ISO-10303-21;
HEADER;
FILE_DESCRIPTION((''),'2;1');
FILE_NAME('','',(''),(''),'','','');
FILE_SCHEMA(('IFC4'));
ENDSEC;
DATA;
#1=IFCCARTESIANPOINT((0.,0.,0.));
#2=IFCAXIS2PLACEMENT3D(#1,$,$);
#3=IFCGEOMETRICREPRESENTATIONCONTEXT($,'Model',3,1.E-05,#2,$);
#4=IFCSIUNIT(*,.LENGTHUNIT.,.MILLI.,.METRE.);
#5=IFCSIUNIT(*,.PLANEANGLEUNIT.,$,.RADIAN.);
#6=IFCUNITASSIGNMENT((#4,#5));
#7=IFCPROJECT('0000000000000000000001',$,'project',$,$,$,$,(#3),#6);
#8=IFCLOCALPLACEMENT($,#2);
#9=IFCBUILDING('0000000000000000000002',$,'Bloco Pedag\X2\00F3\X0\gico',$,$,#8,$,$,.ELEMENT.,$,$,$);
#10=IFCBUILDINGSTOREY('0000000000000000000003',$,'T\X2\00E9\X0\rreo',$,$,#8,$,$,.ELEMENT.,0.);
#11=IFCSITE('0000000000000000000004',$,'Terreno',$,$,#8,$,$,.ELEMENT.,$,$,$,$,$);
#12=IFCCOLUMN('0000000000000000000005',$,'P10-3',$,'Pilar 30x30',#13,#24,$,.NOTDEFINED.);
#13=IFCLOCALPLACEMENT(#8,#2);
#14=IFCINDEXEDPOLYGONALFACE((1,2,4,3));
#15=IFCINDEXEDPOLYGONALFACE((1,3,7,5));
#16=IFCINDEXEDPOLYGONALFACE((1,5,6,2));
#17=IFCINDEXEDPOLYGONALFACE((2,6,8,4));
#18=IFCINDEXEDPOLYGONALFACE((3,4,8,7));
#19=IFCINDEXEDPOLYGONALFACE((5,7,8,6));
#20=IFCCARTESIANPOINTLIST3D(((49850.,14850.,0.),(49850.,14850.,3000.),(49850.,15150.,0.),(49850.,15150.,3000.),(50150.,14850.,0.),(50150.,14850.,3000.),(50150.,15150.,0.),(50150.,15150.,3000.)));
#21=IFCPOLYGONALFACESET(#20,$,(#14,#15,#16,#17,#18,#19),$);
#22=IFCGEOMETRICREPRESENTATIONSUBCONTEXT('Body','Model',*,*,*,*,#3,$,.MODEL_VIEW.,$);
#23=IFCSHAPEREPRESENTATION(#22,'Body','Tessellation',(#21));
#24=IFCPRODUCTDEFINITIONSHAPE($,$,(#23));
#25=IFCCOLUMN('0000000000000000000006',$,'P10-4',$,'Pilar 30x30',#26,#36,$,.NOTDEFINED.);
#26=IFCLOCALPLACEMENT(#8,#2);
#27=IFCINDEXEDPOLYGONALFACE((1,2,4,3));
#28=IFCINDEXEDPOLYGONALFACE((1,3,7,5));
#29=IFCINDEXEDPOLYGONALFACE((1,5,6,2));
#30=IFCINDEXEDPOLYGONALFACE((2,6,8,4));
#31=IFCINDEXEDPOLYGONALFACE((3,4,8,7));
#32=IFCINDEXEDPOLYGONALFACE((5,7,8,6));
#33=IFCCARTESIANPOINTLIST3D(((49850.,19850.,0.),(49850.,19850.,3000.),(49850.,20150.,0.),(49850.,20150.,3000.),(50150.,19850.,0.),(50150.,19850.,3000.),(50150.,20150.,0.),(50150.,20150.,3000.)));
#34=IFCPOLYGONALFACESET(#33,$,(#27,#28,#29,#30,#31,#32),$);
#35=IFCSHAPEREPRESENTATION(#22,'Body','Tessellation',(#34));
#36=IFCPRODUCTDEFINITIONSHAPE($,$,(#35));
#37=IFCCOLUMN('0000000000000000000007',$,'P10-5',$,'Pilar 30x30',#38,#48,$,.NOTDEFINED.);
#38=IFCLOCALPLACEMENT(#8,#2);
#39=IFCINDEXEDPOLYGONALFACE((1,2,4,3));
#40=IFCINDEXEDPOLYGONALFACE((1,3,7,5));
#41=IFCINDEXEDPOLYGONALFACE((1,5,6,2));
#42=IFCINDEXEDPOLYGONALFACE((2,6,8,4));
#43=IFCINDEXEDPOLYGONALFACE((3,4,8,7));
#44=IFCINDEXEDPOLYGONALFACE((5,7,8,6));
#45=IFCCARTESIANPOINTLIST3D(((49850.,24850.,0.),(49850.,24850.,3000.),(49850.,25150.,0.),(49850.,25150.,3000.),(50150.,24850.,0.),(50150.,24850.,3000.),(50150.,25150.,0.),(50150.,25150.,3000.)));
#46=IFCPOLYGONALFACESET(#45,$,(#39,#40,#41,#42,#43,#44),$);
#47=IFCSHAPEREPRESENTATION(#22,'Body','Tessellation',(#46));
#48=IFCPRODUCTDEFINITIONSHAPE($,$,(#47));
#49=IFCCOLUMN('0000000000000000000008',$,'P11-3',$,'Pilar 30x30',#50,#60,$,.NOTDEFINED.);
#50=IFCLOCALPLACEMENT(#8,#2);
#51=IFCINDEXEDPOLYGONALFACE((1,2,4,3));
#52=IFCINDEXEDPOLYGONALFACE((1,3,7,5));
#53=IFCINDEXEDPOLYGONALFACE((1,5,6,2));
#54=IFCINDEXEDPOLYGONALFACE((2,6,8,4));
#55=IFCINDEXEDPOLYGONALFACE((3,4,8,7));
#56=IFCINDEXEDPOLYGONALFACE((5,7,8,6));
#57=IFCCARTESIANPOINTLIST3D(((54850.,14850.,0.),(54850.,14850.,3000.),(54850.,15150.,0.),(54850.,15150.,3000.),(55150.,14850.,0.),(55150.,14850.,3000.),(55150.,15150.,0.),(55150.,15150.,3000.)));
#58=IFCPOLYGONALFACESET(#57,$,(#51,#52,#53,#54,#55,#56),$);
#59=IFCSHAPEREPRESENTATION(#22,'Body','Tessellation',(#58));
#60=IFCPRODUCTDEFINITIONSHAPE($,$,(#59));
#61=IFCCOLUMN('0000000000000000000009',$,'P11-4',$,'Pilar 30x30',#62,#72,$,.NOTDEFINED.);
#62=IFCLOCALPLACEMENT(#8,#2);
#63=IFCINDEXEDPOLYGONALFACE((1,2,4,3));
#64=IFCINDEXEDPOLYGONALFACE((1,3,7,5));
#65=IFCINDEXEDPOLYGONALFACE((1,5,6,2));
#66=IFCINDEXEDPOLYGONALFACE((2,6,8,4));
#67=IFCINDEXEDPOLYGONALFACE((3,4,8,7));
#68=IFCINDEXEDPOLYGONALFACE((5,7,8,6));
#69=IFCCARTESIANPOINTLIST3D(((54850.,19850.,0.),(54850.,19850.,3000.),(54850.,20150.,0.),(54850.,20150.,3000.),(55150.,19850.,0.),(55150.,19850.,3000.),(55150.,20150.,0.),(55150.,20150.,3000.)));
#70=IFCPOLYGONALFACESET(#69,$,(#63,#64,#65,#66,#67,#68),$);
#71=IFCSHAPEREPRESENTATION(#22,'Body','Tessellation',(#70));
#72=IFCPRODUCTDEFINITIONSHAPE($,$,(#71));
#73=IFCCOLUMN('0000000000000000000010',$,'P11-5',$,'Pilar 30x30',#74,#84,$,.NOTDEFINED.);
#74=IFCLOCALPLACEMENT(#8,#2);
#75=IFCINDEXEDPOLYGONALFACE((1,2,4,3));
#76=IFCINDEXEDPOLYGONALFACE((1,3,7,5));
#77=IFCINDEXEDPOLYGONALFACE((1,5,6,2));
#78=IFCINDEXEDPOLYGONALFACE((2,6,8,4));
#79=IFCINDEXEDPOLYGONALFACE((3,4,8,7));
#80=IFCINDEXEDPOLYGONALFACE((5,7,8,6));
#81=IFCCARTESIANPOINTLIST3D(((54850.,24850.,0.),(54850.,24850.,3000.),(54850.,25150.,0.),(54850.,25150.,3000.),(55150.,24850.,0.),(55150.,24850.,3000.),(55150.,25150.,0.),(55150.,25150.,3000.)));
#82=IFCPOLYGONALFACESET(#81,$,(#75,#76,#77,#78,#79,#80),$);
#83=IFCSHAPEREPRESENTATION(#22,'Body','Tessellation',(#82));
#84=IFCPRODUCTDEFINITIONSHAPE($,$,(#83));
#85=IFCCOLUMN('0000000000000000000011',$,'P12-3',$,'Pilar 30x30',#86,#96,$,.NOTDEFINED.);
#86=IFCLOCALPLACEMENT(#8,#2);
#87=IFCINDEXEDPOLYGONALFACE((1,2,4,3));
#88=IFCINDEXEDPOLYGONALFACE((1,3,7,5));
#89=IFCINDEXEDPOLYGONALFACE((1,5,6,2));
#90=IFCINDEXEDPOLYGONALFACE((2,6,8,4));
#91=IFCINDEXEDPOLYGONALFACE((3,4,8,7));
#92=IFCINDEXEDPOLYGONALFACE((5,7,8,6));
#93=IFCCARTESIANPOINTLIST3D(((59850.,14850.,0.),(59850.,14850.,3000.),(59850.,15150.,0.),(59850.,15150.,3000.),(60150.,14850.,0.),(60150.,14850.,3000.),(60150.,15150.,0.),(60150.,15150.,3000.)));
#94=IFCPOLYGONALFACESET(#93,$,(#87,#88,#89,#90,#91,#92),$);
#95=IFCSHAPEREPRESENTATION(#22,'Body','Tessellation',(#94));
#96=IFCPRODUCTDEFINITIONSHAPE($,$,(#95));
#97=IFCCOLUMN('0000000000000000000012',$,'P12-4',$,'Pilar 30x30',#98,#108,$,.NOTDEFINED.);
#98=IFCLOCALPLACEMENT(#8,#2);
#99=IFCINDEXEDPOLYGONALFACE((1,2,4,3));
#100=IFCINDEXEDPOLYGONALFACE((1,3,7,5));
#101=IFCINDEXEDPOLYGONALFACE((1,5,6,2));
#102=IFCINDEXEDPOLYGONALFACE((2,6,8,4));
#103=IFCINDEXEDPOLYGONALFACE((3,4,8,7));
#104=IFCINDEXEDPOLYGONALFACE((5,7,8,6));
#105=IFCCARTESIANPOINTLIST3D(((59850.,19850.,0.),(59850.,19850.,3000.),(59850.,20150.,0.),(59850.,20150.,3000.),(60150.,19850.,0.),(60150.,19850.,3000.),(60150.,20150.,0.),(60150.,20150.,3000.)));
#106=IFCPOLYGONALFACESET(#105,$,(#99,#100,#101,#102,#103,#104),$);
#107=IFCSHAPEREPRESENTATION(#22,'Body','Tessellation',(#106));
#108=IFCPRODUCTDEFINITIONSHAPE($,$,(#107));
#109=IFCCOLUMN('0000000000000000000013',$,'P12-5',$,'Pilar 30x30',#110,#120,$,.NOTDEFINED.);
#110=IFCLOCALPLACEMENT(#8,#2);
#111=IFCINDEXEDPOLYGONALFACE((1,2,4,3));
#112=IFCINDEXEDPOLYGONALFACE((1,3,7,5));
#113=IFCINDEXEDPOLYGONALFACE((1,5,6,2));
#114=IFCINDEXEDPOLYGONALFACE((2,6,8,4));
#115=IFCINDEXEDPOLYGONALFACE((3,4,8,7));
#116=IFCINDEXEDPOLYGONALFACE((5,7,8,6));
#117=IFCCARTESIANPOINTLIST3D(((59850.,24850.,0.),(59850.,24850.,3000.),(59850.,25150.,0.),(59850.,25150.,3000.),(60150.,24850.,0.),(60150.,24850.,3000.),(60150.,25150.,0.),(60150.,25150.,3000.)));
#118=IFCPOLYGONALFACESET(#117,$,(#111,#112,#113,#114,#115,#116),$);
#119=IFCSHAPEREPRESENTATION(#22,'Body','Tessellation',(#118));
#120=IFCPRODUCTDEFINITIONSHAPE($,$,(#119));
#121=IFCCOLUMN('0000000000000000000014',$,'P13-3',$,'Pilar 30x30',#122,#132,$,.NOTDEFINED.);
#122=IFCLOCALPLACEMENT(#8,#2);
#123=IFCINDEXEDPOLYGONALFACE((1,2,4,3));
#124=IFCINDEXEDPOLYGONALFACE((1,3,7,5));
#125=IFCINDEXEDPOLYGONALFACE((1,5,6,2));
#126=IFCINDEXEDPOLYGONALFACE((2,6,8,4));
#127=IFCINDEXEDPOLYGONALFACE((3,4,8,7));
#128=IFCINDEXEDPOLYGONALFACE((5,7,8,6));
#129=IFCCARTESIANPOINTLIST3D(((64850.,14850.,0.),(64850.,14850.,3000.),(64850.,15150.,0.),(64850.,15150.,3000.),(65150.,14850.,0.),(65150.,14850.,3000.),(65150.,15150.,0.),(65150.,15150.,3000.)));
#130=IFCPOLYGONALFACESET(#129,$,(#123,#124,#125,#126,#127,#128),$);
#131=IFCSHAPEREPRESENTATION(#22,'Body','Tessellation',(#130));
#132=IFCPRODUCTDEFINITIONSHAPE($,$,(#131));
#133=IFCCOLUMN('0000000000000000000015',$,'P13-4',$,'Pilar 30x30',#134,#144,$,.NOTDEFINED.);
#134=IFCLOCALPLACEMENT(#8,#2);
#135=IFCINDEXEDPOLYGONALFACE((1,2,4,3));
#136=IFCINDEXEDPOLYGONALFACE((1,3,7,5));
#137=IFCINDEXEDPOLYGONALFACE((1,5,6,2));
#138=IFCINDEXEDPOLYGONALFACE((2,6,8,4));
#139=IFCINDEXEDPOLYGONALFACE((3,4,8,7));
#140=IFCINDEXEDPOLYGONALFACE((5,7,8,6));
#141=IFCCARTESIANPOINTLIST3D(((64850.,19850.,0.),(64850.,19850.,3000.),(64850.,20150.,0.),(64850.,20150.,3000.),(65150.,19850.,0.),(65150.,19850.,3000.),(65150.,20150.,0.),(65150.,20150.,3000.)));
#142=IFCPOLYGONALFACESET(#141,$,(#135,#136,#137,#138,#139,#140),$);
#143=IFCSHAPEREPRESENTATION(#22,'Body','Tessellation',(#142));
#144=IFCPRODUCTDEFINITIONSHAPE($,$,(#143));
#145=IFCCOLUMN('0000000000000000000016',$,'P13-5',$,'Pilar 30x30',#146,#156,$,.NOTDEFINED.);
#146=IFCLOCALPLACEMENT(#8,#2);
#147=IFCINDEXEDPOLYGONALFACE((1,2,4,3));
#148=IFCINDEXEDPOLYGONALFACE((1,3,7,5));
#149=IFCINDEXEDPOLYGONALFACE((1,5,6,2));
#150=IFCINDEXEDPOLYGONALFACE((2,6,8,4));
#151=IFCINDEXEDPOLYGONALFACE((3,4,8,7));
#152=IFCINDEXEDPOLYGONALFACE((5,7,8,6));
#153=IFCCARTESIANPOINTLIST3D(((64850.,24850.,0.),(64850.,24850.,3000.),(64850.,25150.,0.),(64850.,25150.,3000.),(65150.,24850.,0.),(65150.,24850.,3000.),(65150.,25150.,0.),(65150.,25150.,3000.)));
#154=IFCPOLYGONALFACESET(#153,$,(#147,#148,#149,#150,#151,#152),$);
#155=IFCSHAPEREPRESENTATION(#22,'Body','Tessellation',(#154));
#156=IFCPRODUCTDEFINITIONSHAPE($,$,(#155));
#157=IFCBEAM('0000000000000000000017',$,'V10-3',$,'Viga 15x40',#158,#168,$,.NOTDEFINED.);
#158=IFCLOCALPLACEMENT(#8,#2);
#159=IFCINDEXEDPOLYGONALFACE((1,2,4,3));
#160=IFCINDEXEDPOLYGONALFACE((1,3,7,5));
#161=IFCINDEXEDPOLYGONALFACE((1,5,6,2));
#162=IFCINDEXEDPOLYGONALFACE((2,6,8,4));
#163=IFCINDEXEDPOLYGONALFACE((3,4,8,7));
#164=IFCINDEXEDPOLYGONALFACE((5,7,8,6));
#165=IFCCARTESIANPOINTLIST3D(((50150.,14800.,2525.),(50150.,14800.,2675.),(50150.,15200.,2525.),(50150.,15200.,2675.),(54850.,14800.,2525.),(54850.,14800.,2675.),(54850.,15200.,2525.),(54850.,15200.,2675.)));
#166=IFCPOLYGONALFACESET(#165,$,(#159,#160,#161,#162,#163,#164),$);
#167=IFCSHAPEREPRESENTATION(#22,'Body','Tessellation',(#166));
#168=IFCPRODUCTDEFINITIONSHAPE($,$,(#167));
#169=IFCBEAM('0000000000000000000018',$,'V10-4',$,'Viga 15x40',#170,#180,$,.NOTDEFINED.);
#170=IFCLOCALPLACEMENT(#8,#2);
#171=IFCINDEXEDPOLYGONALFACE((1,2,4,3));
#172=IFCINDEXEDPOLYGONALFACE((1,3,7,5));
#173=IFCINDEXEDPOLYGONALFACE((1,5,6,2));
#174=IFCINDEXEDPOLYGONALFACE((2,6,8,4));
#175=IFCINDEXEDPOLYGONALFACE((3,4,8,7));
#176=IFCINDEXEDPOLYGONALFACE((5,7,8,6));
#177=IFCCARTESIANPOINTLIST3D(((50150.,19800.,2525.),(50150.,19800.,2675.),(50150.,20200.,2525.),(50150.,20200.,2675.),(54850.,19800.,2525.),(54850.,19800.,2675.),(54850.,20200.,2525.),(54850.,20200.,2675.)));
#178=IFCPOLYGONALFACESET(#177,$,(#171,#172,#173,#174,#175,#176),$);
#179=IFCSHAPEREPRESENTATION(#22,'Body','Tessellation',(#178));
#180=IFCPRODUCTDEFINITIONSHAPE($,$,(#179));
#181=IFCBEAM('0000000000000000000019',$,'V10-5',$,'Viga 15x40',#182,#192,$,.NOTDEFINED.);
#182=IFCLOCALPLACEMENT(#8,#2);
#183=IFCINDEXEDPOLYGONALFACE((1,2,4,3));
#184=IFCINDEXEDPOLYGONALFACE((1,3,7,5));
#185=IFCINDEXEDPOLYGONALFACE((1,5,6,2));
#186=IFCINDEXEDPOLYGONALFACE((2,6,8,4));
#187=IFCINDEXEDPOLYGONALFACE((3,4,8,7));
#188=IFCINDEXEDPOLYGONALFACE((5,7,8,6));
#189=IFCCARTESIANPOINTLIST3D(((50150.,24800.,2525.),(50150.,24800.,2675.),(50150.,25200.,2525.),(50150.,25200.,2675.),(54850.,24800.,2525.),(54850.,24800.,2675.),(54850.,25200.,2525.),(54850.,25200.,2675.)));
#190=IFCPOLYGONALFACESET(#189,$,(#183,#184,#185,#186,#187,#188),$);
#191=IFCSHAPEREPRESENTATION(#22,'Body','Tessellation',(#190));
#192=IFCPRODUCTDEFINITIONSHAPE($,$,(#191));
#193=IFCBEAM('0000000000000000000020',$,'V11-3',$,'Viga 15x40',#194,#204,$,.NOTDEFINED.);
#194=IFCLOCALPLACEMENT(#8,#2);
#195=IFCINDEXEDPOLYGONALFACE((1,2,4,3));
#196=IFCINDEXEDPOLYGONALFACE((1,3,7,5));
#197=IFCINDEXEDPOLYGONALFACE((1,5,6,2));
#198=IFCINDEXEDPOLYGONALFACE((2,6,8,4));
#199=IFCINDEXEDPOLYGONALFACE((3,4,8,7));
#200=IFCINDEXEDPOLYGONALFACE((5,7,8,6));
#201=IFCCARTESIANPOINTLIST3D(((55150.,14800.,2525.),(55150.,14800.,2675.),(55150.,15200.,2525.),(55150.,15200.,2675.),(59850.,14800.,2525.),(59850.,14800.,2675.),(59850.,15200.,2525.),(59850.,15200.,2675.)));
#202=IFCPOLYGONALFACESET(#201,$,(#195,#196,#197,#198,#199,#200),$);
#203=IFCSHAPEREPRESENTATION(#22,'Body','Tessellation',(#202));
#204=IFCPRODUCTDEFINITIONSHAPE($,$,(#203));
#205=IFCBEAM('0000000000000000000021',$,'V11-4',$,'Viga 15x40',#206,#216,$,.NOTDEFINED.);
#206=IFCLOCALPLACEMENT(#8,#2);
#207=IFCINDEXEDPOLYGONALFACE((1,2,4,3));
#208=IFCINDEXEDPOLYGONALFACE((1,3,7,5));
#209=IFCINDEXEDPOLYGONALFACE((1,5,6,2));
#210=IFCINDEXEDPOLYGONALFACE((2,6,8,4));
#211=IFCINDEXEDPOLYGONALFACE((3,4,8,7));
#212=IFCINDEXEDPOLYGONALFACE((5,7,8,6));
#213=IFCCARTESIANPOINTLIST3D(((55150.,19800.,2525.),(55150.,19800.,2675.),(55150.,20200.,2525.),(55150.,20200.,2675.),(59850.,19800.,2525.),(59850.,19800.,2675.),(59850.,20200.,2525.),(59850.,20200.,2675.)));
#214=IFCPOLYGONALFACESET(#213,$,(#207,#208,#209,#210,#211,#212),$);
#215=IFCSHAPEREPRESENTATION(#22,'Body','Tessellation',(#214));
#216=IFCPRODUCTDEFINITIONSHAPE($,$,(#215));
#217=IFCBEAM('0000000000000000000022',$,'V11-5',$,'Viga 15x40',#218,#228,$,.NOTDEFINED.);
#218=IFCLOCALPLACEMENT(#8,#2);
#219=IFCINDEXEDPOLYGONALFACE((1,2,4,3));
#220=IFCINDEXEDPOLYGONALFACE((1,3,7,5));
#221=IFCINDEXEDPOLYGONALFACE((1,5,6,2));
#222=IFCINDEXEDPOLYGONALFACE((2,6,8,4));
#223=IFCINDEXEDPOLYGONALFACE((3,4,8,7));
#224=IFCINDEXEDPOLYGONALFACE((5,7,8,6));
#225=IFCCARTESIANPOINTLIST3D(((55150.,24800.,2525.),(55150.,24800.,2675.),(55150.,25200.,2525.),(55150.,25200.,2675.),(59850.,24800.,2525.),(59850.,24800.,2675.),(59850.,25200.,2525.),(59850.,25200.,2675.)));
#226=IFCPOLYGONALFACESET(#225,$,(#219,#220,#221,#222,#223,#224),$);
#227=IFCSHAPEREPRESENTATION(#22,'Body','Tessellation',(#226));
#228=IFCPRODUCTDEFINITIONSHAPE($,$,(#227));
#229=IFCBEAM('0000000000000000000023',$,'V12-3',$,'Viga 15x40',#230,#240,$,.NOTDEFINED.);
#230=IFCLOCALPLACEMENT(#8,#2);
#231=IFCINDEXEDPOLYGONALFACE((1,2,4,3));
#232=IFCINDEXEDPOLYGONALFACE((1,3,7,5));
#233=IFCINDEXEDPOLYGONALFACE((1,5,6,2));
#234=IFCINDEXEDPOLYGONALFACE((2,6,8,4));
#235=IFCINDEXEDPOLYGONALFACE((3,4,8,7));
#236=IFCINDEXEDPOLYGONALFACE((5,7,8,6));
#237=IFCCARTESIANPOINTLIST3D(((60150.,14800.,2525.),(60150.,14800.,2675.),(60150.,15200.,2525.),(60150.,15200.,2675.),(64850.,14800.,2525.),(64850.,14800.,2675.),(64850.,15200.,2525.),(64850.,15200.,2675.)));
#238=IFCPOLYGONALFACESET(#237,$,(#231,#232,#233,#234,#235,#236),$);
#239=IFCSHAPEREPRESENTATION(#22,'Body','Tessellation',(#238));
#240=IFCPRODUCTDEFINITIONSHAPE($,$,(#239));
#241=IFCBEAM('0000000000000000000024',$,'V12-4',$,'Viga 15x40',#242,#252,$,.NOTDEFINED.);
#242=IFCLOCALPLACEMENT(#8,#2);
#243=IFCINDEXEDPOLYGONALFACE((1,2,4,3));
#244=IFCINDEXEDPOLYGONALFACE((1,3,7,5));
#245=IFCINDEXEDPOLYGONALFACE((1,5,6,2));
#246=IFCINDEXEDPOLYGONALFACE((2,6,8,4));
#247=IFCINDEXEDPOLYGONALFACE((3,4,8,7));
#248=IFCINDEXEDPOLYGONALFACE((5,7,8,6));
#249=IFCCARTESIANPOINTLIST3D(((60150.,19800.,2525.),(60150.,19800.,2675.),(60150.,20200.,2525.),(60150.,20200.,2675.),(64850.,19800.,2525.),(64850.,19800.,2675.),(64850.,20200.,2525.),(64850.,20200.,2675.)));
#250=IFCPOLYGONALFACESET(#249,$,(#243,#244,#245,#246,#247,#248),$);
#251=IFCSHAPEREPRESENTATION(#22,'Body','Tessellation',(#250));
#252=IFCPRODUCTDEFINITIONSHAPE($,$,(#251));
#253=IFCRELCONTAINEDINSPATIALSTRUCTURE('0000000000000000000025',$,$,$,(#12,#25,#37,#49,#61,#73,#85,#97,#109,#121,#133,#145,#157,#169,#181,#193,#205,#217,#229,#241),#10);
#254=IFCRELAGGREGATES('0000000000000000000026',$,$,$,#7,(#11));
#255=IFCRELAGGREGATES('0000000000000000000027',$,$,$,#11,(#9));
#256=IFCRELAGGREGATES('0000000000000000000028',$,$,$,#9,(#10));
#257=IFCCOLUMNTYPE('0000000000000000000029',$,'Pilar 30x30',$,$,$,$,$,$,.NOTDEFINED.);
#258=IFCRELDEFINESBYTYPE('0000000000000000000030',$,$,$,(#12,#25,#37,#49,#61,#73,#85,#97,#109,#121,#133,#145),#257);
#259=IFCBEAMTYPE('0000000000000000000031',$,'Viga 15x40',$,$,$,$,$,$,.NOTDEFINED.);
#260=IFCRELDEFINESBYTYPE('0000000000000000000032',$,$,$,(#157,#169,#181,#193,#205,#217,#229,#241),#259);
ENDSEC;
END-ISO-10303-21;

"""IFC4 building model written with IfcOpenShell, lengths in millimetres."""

from ifc_helpers import new_model, si_unit, frame, origin, origin_2d, place, context, subcontext, project, spatial, rectangle, extrude, type_object, element, save


model = new_model("IFC4")

# Units and contexts
model_context = context("Model", 3, precision=1e-05, world=origin())
body_context = subcontext(model_context, "Body", "Model", "MODEL_VIEW")
ifc_project = project(units=[si_unit("LENGTHUNIT", "METRE", prefix="MILLI"), si_unit("PLANEANGLEUNIT", "RADIAN")], contexts=[model_context])

# Site, building, storey
placement = place(None, origin())
site = spatial("IfcSite", under=ifc_project, at=placement, Name="Terreno", CompositionType="ELEMENT")
building = spatial("IfcBuilding", under=site, at=placement, Name="Bloco Pedagógico", CompositionType="ELEMENT")
storey = spatial("IfcBuildingStorey", under=building, at=placement, Name="Térreo", CompositionType="ELEMENT", Elevation=0.0)

# Columns
column_type = type_object("IfcColumnType", Name="Pilar 30x30", PredefinedType="NOTDEFINED")
for number, where, z_axis, x_axis, name in (
    (1, (50000.0, 15000.0, 0.0), (0.0, 0.0, 1.0), (1.0, 0.0, 0.0), "P10-3"),
    (2, (50000.0, 20000.0, 0.0), (0.0, 0.0, 1.0), (1.0, 0.0, 0.0), "P10-4"),
    (3, (50000.0, 25000.0, 0.0), (0.0, 0.0, 1.0), (1.0, 0.0, 0.0), "P10-5"),
    (4, (55000.0, 15000.0, 0.0), (0.0, 0.0, 1.0), (1.0, 0.0, 0.0), "P11-3"),
    (5, (55000.0, 20000.0, 0.0), (0.0, 0.0, 1.0), (1.0, 0.0, 0.0), "P11-4"),
    (6, (55000.0, 25000.0, 0.0), (0.0, 0.0, 1.0), (1.0, 0.0, 0.0), "P11-5"),
    (7, (60000.0, 15000.0, 0.0), (0.0, 0.0, 1.0), (1.0, 0.0, 0.0), "P12-3"),
    (8, (60000.0, 20000.0, 0.0), (0.0, 0.0, 1.0), (1.0, 0.0, 0.0), "P12-4"),
    (9, (60000.0, 25000.0, 0.0), (0.0, 0.0, 1.0), (1.0, 0.0, 0.0), "P12-5"),
    (10, (65000.0, 15000.0, 0.0), (0.0, 0.0, 1.0), (1.0, 0.0, 0.0), "P13-3"),
    (11, (65000.0, 20000.0, 0.0), (0.0, 0.0, 1.0), (1.0, 0.0, 0.0), "P13-4"),
    (12, (65000.0, 25000.0, 0.0), (0.0, 0.0, 1.0), (1.0, 0.0, 0.0), "P13-5"),
):
    element("IfcColumn", number, at=place(None, frame(where, z_axis=z_axis, x_axis=x_axis)), inside=storey, type_object=column_type, Name=name, ObjectType="Pilar 30x30", PredefinedType="NOTDEFINED", context=body_context, shape_type="SweptSolid", body=[
        extrude(rectangle(XDim=300.0, YDim=300.0, at=origin_2d()), None, (0.0, 0.0, 1.0), 3000.0),
    ])

# Beams
beam_type = type_object("IfcBeamType", Name="Viga 15x40", PredefinedType="NOTDEFINED")
for number, where, z_axis, x_axis, name in (
    (13, (50150.0, 15000.0, 2600.0), (1.0, 0.0, 0.0), (0.0, 1.0, 0.0), "V10-3"),
    (14, (50150.0, 20000.0, 2600.0), (1.0, 0.0, 0.0), (0.0, 1.0, 0.0), "V10-4"),
    (15, (50150.0, 25000.0, 2600.0), (1.0, 0.0, 0.0), (0.0, 1.0, 0.0), "V10-5"),
    (16, (55150.0, 15000.0, 2600.0), (1.0, 0.0, 0.0), (0.0, 1.0, 0.0), "V11-3"),
    (17, (55150.0, 20000.0, 2600.0), (1.0, 0.0, 0.0), (0.0, 1.0, 0.0), "V11-4"),
    (18, (55150.0, 25000.0, 2600.0), (1.0, 0.0, 0.0), (0.0, 1.0, 0.0), "V11-5"),
    (19, (60150.0, 15000.0, 2600.0), (1.0, 0.0, 0.0), (0.0, 1.0, 0.0), "V12-3"),
    (20, (60150.0, 20000.0, 2600.0), (1.0, 0.0, 0.0), (0.0, 1.0, 0.0), "V12-4"),
):
    element("IfcBeam", number, at=place(None, frame(where, z_axis=z_axis, x_axis=x_axis)), inside=storey, type_object=beam_type, Name=name, ObjectType="Viga 15x40", PredefinedType="NOTDEFINED", context=body_context, shape_type="SweptSolid", body=[
        extrude(rectangle(XDim=400.0, YDim=150.0, at=origin_2d()), None, (0.0, 0.0, 1.0), 4700.0),
    ])

save(model, "model.ifc")
